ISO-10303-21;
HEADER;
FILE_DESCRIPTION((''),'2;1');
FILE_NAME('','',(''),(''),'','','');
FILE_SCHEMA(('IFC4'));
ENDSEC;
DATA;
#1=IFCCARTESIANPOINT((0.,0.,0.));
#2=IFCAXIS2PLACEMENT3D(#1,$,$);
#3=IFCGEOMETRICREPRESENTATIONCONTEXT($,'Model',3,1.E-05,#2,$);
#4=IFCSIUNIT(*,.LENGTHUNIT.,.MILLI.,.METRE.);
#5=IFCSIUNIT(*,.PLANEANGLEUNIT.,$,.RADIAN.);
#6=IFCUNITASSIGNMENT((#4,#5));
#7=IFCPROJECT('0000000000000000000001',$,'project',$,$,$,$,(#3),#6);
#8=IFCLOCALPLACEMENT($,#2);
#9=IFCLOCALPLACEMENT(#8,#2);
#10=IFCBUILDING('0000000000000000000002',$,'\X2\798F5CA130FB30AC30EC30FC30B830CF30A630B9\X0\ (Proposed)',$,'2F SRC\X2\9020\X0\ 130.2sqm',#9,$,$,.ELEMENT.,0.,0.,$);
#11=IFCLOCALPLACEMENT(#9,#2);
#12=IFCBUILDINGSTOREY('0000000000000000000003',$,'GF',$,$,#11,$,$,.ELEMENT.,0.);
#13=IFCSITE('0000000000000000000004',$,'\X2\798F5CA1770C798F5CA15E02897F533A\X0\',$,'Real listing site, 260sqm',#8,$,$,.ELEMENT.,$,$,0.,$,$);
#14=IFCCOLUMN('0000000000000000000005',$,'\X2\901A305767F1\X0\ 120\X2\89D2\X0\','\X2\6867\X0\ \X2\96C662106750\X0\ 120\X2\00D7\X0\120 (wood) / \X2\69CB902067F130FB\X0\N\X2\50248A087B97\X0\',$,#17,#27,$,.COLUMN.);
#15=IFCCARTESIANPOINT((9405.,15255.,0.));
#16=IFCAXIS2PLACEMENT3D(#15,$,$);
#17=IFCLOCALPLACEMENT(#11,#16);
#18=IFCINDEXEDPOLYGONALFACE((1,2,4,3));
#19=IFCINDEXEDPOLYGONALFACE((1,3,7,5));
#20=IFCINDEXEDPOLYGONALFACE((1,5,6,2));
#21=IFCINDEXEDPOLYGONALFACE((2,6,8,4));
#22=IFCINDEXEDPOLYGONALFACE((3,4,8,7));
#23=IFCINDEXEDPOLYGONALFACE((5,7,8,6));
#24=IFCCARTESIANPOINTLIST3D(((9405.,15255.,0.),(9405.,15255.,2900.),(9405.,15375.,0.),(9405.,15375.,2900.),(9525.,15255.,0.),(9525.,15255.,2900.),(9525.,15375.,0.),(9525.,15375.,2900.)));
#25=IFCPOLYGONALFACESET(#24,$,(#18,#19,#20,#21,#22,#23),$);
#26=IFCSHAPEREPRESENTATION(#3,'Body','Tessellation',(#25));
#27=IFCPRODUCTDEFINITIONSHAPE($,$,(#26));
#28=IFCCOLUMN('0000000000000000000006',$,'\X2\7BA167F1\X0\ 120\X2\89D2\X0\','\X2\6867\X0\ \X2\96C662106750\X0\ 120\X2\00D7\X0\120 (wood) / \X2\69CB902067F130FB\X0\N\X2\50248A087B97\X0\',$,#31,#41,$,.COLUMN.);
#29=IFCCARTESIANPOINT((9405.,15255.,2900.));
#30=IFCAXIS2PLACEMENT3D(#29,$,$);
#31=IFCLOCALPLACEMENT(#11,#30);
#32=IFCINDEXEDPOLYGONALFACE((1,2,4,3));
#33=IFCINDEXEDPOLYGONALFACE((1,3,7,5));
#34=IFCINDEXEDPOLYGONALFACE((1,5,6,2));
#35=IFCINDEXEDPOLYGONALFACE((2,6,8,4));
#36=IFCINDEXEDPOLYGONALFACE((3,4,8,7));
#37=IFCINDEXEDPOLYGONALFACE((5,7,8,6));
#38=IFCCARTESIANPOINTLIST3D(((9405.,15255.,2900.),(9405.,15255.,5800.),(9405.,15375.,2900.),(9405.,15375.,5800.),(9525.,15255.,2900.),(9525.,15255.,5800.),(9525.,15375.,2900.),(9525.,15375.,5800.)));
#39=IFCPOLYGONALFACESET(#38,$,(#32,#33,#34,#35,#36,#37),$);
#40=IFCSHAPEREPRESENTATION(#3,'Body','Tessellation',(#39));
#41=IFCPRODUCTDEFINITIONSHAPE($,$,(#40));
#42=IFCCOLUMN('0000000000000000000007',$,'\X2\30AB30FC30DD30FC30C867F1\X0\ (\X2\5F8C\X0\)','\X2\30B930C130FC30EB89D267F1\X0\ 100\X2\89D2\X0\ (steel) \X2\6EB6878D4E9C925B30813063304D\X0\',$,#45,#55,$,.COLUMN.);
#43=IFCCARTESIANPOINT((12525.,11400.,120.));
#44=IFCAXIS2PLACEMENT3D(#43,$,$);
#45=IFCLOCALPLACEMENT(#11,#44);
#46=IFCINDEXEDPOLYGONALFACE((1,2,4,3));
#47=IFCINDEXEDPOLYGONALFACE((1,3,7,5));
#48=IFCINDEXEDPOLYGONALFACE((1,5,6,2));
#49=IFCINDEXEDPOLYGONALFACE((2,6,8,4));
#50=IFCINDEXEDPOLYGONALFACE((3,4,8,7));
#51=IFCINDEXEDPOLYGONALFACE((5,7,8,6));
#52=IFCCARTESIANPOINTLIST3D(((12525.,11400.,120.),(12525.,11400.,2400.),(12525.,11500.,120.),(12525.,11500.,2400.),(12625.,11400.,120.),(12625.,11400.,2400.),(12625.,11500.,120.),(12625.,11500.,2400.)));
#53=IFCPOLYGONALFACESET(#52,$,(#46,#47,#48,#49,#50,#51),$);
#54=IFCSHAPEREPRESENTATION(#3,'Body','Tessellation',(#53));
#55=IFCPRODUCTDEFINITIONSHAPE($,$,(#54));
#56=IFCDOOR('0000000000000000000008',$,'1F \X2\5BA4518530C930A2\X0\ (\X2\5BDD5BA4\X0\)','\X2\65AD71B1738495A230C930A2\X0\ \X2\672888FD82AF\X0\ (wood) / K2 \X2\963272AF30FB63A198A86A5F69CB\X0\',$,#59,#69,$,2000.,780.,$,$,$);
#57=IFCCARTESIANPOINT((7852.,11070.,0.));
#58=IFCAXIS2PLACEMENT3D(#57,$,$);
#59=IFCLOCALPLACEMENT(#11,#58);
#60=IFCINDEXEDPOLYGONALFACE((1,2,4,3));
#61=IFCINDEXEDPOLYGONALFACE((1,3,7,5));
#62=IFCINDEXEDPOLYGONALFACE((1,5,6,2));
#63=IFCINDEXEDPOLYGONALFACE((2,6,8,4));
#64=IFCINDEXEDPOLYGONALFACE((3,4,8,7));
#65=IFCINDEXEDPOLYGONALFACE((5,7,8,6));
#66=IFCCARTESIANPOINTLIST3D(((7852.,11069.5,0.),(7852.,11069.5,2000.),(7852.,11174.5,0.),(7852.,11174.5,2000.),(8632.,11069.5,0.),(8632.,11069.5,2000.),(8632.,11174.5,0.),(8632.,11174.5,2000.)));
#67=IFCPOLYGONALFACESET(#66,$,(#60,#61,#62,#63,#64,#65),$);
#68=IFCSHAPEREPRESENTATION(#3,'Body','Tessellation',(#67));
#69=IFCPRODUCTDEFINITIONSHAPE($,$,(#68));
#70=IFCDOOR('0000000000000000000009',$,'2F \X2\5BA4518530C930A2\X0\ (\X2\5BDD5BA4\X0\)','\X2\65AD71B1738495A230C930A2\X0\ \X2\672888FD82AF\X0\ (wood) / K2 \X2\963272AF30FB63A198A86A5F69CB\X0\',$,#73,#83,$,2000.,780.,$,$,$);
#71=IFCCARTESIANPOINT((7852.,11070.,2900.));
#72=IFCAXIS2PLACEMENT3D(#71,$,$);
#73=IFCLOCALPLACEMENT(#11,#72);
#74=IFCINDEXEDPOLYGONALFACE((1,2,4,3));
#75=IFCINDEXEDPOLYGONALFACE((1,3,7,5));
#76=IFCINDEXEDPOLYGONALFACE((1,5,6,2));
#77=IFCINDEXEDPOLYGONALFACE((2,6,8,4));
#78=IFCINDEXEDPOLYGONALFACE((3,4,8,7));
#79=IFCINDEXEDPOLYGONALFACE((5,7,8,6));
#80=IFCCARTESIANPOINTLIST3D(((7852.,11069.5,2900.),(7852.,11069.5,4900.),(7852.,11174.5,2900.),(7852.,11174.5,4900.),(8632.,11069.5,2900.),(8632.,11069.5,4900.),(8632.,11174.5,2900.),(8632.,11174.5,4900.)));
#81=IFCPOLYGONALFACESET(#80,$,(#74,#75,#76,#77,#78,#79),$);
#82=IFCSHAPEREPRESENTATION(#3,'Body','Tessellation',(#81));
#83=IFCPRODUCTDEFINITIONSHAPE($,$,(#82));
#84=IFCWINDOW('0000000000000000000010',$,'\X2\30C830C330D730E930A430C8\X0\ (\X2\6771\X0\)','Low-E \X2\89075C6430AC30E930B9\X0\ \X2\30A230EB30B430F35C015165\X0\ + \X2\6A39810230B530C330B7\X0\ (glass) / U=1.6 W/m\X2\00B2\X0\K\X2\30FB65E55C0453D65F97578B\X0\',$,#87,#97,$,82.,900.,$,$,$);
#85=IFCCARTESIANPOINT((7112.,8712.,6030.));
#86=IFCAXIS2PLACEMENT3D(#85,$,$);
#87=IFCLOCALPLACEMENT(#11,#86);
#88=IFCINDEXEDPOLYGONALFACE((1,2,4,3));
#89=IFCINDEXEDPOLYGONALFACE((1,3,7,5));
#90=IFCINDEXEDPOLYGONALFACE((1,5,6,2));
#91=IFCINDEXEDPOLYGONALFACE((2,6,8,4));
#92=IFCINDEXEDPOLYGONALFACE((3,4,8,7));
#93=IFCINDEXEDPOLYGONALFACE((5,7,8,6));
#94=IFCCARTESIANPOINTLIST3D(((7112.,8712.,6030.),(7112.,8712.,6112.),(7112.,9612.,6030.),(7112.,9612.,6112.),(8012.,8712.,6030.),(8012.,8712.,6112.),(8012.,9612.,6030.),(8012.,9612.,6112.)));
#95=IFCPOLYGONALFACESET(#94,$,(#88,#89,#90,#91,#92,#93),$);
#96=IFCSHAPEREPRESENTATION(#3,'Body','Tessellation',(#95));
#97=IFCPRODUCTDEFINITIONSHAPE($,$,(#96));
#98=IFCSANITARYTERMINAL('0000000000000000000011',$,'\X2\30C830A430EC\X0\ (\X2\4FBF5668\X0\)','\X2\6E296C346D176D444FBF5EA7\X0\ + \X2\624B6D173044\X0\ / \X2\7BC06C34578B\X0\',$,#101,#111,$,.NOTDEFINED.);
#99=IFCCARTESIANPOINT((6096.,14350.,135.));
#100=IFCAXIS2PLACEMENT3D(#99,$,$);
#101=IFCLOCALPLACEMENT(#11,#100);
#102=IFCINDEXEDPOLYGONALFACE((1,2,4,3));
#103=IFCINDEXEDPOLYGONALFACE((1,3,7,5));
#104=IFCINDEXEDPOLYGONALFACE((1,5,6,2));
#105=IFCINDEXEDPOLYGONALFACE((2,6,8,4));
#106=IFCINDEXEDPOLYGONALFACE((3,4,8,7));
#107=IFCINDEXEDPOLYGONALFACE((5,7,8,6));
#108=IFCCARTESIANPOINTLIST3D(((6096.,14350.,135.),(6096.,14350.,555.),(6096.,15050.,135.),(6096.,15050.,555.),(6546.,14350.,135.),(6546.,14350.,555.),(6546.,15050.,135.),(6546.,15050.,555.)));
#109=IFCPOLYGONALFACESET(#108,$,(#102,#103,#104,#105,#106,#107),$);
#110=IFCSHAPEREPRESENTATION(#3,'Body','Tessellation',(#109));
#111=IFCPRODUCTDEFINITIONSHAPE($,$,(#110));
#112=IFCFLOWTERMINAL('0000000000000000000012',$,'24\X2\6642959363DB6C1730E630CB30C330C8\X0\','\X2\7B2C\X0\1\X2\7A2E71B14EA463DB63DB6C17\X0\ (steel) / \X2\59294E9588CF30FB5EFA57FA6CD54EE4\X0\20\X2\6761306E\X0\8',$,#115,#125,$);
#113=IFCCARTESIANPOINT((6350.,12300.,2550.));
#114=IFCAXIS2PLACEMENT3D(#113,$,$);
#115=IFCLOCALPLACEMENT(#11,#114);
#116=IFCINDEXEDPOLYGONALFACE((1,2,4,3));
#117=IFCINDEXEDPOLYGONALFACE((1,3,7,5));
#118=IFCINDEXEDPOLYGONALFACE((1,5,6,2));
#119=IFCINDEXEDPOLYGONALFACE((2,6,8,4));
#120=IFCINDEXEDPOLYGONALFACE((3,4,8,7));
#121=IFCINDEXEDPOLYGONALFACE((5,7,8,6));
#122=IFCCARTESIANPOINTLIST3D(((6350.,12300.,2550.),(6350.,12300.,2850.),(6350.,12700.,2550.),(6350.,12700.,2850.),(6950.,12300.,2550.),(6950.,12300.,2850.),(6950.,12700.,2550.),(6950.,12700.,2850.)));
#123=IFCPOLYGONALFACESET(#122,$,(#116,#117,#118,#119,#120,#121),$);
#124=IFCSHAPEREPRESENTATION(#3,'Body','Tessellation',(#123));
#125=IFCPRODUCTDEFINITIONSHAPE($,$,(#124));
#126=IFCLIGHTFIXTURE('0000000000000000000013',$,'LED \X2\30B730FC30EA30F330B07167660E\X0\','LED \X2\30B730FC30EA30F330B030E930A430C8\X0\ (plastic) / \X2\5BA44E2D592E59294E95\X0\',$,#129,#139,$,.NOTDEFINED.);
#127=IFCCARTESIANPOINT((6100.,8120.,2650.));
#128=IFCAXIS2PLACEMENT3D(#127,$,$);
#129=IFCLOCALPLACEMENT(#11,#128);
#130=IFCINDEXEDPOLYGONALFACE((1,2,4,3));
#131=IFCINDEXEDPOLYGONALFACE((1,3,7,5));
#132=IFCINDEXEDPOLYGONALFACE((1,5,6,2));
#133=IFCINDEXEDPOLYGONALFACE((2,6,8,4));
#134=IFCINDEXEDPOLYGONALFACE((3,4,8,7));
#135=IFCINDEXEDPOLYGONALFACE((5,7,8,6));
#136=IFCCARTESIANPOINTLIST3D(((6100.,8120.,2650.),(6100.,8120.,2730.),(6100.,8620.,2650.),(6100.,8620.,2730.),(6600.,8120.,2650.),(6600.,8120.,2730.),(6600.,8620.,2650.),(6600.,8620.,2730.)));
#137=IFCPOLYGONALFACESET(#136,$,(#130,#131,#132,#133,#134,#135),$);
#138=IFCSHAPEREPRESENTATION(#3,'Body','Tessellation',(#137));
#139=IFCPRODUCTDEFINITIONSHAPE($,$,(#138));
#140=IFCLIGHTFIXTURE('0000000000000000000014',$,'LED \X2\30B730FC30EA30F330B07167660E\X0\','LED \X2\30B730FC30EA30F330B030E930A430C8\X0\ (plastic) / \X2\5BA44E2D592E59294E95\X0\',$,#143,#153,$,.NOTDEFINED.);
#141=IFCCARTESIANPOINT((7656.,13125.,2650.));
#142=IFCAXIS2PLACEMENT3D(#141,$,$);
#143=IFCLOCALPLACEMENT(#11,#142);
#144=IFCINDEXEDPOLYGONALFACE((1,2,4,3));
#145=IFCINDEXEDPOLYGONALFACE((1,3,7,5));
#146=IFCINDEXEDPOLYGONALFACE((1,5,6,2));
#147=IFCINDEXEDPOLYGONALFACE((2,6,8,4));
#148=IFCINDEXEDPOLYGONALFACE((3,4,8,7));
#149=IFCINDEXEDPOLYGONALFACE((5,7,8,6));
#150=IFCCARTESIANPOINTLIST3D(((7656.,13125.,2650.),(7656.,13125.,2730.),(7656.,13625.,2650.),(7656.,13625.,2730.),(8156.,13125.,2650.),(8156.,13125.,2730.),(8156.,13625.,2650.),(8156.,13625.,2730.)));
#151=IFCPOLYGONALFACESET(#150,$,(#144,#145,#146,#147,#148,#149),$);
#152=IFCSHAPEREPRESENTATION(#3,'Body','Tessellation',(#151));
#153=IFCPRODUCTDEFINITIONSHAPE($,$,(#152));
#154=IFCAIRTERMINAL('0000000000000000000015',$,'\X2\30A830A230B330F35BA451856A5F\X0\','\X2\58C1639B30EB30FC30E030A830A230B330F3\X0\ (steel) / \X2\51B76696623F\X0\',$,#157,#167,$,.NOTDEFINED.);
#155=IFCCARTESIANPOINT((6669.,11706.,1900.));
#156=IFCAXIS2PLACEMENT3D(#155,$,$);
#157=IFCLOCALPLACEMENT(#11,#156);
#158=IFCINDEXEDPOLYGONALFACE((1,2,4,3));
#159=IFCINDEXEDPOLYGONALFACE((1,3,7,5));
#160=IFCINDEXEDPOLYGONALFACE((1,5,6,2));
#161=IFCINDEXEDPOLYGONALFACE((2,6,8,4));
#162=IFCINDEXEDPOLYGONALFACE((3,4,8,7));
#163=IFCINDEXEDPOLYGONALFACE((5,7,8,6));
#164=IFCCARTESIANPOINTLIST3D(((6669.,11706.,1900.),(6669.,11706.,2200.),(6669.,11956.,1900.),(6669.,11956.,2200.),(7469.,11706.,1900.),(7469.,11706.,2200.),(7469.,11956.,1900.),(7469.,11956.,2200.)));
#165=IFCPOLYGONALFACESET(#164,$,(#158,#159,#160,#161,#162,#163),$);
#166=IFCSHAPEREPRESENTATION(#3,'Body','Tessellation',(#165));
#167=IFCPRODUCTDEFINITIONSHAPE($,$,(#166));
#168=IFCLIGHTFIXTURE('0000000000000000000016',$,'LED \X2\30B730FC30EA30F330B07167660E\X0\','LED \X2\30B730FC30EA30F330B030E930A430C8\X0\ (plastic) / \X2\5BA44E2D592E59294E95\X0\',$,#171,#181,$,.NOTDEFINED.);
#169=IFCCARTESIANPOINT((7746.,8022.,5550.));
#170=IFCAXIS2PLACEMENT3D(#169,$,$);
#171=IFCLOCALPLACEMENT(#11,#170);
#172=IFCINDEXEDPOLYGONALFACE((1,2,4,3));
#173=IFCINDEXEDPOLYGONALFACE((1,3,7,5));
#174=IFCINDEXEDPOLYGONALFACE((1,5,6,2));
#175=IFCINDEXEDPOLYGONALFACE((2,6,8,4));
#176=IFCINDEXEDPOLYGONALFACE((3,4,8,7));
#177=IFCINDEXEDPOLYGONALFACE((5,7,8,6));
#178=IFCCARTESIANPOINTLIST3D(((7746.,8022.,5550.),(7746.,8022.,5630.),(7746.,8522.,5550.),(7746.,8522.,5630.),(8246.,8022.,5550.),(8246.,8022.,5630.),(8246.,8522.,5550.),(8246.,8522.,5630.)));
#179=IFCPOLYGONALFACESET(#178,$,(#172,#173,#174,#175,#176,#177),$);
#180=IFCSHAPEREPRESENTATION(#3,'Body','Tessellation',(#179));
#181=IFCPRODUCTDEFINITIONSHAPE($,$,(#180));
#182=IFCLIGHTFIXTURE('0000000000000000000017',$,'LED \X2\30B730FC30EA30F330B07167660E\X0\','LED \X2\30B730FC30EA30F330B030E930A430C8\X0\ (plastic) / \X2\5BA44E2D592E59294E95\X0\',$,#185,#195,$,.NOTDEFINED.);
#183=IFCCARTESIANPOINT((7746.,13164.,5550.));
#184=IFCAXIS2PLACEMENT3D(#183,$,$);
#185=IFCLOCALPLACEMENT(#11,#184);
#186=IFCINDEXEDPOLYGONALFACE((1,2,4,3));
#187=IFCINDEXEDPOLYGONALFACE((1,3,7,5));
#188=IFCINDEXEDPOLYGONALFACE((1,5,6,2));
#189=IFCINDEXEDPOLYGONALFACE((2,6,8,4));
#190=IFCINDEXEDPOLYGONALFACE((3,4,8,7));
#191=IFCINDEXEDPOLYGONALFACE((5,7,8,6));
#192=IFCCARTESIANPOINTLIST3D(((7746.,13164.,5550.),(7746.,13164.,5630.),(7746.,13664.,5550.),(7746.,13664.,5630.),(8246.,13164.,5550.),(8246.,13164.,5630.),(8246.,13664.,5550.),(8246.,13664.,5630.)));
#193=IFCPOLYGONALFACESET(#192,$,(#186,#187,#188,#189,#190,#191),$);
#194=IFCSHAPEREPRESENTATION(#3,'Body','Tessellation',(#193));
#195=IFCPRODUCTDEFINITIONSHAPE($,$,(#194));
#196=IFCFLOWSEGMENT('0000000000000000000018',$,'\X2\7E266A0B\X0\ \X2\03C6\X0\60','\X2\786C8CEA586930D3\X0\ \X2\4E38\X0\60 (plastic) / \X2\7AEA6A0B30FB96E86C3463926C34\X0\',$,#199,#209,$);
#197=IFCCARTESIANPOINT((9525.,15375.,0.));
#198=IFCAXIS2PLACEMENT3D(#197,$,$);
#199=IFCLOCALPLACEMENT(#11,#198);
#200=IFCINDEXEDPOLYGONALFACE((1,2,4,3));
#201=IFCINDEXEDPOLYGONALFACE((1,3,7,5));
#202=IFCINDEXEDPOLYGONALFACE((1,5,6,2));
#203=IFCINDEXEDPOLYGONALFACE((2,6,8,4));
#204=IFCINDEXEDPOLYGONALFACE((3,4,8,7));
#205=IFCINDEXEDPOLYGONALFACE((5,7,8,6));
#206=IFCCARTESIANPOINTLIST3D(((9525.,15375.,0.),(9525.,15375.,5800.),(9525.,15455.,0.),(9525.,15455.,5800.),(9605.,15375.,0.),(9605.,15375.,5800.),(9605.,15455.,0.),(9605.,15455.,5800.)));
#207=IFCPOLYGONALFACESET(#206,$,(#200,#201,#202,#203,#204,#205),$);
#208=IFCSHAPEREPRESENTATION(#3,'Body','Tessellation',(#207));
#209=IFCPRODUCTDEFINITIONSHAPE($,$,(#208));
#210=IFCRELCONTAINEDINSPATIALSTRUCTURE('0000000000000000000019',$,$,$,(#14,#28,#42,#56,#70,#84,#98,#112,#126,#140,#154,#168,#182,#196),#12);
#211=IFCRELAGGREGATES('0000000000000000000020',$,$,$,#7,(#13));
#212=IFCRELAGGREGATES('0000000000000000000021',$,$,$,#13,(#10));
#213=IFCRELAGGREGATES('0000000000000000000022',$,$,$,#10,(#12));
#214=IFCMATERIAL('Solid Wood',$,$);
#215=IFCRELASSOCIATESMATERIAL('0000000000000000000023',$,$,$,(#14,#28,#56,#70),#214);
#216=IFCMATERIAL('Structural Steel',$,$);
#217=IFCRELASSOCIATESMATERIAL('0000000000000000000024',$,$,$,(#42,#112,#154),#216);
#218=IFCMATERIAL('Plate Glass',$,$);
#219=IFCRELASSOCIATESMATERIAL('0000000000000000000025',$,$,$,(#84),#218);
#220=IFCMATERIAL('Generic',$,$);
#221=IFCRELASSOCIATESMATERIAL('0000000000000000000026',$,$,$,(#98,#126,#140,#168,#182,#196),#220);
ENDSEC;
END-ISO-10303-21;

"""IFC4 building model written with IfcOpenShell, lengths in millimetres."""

from ifc_helpers import new_model, si_unit, frame, frame_2d, origin, place, context, project, spatial, rectangle, extrude, material, element, save


model = new_model("IFC4")

# Units and contexts
model_context = context("Model", 3, precision=1e-05, world=origin())
ifc_project = project(units=[si_unit("LENGTHUNIT", "METRE", prefix="MILLI"), si_unit("PLANEANGLEUNIT", "RADIAN")], contexts=[model_context])

# Site, building, storey
site_placement = place(None, origin())
site = spatial("IfcSite", under=ifc_project, at=site_placement, Name="福岡県福岡市西区", ObjectType="Real listing site, 260sqm", CompositionType="ELEMENT", RefElevation=0.0)
building_placement = place(site_placement, origin())
building = spatial("IfcBuilding", under=site, at=building_placement, Name="福岡・ガレージハウス (Proposed)", ObjectType="2F SRC造 130.2sqm", CompositionType="ELEMENT", ElevationOfRefHeight=0.0, ElevationOfTerrain=0.0)
storey_placement = place(building_placement, origin())
storey = spatial("IfcBuildingStorey", under=building, at=storey_placement, Name="GF", CompositionType="ELEMENT", Elevation=0.0)

# Columns
ifc_material_1 = material(Name="Solid Wood")
column_1_placement = place(storey_placement, frame((9405.0, 15255.0, 0.0)))
element("IfcColumn", 1, at=column_1_placement, inside=storey, material=ifc_material_1, Name="通し柱 120角", Description="桧 集成材 120×120 (wood) / 構造柱・N値計算", PredefinedType="COLUMN", context=model_context, shape_type="SweptSolid", body=[
    extrude(rectangle(XDim=120.0, YDim=120.0, at=frame_2d((60.0, 60.0))), frame((9405.0, 15255.0, 0.0)), (0.0, 0.0, 1.0), 2900.0),
])
column_2_placement = place(storey_placement, frame((9405.0, 15255.0, 2900.0)))
element("IfcColumn", 2, at=column_2_placement, inside=storey, material=ifc_material_1, Name="管柱 120角", Description="桧 集成材 120×120 (wood) / 構造柱・N値計算", PredefinedType="COLUMN", context=model_context, shape_type="SweptSolid", body=[
    extrude(rectangle(XDim=120.0, YDim=120.0, at=frame_2d((60.0, 60.0))), frame((9405.0, 15255.0, 2900.0)), (0.0, 0.0, 1.0), 2900.0),
])
ifc_material_2 = material(Name="Structural Steel")
column_3_placement = place(storey_placement, frame((12525.0, 11400.0, 120.0)))
element("IfcColumn", 3, at=column_3_placement, inside=storey, material=ifc_material_2, Name="カーポート柱 (後)", Description="スチール角柱 100角 (steel) 溶融亜鉛めっき", PredefinedType="COLUMN", context=model_context, shape_type="SweptSolid", body=[
    extrude(rectangle(XDim=100.0, YDim=100.0, at=frame_2d((50.0, 50.0))), frame((12525.0, 11400.0, 120.0)), (0.0, 0.0, 1.0), 2280.0),
])

# Door
door_1_placement = place(storey_placement, frame((7852.0, 11070.0, 0.0)))
element("IfcDoor", 4, at=door_1_placement, inside=storey, material=ifc_material_1, Name="1F 室内ドア (寝室)", Description="断熱玄関ドア 木製芯 (wood) / K2 防犯・採風機構", OverallHeight=2000.0, OverallWidth=780.0, context=model_context, shape_type="SweptSolid", body=[
    extrude(rectangle(XDim=780.0, YDim=105.0, at=frame_2d((390.0, 52.0))), frame((7852.0, 11070.0, 0.0)), (0.0, 0.0, 1.0), 2000.0),
])

# Door
door_2_placement = place(storey_placement, frame((7852.0, 11070.0, 2900.0)))
element("IfcDoor", 5, at=door_2_placement, inside=storey, material=ifc_material_1, Name="2F 室内ドア (寝室)", Description="断熱玄関ドア 木製芯 (wood) / K2 防犯・採風機構", OverallHeight=2000.0, OverallWidth=780.0, context=model_context, shape_type="SweptSolid", body=[
    extrude(rectangle(XDim=780.0, YDim=105.0, at=frame_2d((390.0, 52.0))), frame((7852.0, 11070.0, 2900.0)), (0.0, 0.0, 1.0), 2000.0),
])

# Window
ifc_material_3 = material(Name="Plate Glass")
window_placement = place(storey_placement, frame((7112.0, 8712.0, 6030.0)))
element("IfcWindow", 6, at=window_placement, inside=storey, material=ifc_material_3, Name="トップライト (東)", Description="Low-E 複層ガラス アルゴン封入 + 樹脂サッシ (glass) / U=1.6 W/m²K・日射取得型", OverallHeight=82.0, OverallWidth=900.0, context=model_context, shape_type="SweptSolid", body=[
    extrude(rectangle(XDim=900.0, YDim=900.0, at=frame_2d((450.0, 450.0))), frame((7112.0, 8712.0, 6030.0)), (0.0, 0.0, 1.0), 82.0),
])

# Sanitary terminal
ifc_material_4 = material(Name="Generic")
sanitary_terminal_placement = place(storey_placement, frame((6096.0, 14350.0, 135.0)))
element("IfcSanitaryTerminal", 7, at=sanitary_terminal_placement, inside=storey, material=ifc_material_4, Name="トイレ (便器)", Description="温水洗浄便座 + 手洗い / 節水型", PredefinedType="NOTDEFINED", context=model_context, shape_type="SweptSolid", body=[
    extrude(rectangle(XDim=450.0, YDim=700.0, at=frame_2d((225.0, 350.0))), frame((6096.0, 14350.0, 135.0)), (0.0, 0.0, 1.0), 420.0),
])

# Flow terminal
flow_terminal_placement = place(storey_placement, frame((6350.0, 12300.0, 2550.0)))
element("IfcFlowTerminal", 8, at=flow_terminal_placement, inside=storey, material=ifc_material_2, Name="24時間換気ユニット", Description="第1種熱交換換気 (steel) / 天井裏・建基法令20条の8", context=model_context, shape_type="SweptSolid", body=[
    extrude(rectangle(XDim=600.0, YDim=400.0, at=frame_2d((300.0, 200.0))), frame((6350.0, 12300.0, 2550.0)), (0.0, 0.0, 1.0), 300.0),
])

# Light fixtures
light_fixture_1_placement = place(storey_placement, frame((6100.0, 8120.0, 2650.0)))
element("IfcLightFixture", 9, at=light_fixture_1_placement, inside=storey, material=ifc_material_4, Name="LED シーリング照明", Description="LED シーリングライト (plastic) / 室中央天井", PredefinedType="NOTDEFINED", context=model_context, shape_type="SweptSolid", body=[
    extrude(rectangle(XDim=500.0, YDim=500.0, at=frame_2d((250.0, 250.0))), frame((6100.0, 8120.0, 2650.0)), (0.0, 0.0, 1.0), 80.0),
])
light_fixture_2_placement = place(storey_placement, frame((7656.0, 13125.0, 2650.0)))
element("IfcLightFixture", 10, at=light_fixture_2_placement, inside=storey, material=ifc_material_4, Name="LED シーリング照明", Description="LED シーリングライト (plastic) / 室中央天井", PredefinedType="NOTDEFINED", context=model_context, shape_type="SweptSolid", body=[
    extrude(rectangle(XDim=500.0, YDim=500.0, at=frame_2d((250.0, 250.0))), frame((7656.0, 13125.0, 2650.0)), (0.0, 0.0, 1.0), 80.0),
])

# Air terminal
air_terminal_placement = place(storey_placement, frame((6669.0, 11706.0, 1900.0)))
element("IfcAirTerminal", 11, at=air_terminal_placement, inside=storey, material=ifc_material_2, Name="エアコン室内機", Description="壁掛ルームエアコン (steel) / 冷暖房", PredefinedType="NOTDEFINED", context=model_context, shape_type="SweptSolid", body=[
    extrude(rectangle(XDim=800.0, YDim=250.0, at=frame_2d((400.0, 125.0))), frame((6669.0, 11706.0, 1900.0)), (0.0, 0.0, 1.0), 300.0),
])

# Light fixtures
light_fixture_3_placement = place(storey_placement, frame((7746.0, 8022.0, 5550.0)))
element("IfcLightFixture", 12, at=light_fixture_3_placement, inside=storey, material=ifc_material_4, Name="LED シーリング照明", Description="LED シーリングライト (plastic) / 室中央天井", PredefinedType="NOTDEFINED", context=model_context, shape_type="SweptSolid", body=[
    extrude(rectangle(XDim=500.0, YDim=500.0, at=frame_2d((250.0, 250.0))), frame((7746.0, 8022.0, 5550.0)), (0.0, 0.0, 1.0), 80.0),
])
light_fixture_4_placement = place(storey_placement, frame((7746.0, 13164.0, 5550.0)))
element("IfcLightFixture", 13, at=light_fixture_4_placement, inside=storey, material=ifc_material_4, Name="LED シーリング照明", Description="LED シーリングライト (plastic) / 室中央天井", PredefinedType="NOTDEFINED", context=model_context, shape_type="SweptSolid", body=[
    extrude(rectangle(XDim=500.0, YDim=500.0, at=frame_2d((250.0, 250.0))), frame((7746.0, 13164.0, 5550.0)), (0.0, 0.0, 1.0), 80.0),
])

# Flow segment
flow_segment_placement = place(storey_placement, frame((9525.0, 15375.0, 0.0)))
element("IfcFlowSegment", 14, at=flow_segment_placement, inside=storey, material=ifc_material_4, Name="縦樋 φ60", Description="硬質塩ビ 丸60 (plastic) / 竪樋・雨水排水", context=model_context, shape_type="SweptSolid", body=[
    extrude(rectangle(XDim=80.0, YDim=80.0, at=frame_2d((40.0, 40.0))), frame((9525.0, 15375.0, 0.0)), (0.0, 0.0, 1.0), 5800.0),
])

save(model, "model.ifc")
